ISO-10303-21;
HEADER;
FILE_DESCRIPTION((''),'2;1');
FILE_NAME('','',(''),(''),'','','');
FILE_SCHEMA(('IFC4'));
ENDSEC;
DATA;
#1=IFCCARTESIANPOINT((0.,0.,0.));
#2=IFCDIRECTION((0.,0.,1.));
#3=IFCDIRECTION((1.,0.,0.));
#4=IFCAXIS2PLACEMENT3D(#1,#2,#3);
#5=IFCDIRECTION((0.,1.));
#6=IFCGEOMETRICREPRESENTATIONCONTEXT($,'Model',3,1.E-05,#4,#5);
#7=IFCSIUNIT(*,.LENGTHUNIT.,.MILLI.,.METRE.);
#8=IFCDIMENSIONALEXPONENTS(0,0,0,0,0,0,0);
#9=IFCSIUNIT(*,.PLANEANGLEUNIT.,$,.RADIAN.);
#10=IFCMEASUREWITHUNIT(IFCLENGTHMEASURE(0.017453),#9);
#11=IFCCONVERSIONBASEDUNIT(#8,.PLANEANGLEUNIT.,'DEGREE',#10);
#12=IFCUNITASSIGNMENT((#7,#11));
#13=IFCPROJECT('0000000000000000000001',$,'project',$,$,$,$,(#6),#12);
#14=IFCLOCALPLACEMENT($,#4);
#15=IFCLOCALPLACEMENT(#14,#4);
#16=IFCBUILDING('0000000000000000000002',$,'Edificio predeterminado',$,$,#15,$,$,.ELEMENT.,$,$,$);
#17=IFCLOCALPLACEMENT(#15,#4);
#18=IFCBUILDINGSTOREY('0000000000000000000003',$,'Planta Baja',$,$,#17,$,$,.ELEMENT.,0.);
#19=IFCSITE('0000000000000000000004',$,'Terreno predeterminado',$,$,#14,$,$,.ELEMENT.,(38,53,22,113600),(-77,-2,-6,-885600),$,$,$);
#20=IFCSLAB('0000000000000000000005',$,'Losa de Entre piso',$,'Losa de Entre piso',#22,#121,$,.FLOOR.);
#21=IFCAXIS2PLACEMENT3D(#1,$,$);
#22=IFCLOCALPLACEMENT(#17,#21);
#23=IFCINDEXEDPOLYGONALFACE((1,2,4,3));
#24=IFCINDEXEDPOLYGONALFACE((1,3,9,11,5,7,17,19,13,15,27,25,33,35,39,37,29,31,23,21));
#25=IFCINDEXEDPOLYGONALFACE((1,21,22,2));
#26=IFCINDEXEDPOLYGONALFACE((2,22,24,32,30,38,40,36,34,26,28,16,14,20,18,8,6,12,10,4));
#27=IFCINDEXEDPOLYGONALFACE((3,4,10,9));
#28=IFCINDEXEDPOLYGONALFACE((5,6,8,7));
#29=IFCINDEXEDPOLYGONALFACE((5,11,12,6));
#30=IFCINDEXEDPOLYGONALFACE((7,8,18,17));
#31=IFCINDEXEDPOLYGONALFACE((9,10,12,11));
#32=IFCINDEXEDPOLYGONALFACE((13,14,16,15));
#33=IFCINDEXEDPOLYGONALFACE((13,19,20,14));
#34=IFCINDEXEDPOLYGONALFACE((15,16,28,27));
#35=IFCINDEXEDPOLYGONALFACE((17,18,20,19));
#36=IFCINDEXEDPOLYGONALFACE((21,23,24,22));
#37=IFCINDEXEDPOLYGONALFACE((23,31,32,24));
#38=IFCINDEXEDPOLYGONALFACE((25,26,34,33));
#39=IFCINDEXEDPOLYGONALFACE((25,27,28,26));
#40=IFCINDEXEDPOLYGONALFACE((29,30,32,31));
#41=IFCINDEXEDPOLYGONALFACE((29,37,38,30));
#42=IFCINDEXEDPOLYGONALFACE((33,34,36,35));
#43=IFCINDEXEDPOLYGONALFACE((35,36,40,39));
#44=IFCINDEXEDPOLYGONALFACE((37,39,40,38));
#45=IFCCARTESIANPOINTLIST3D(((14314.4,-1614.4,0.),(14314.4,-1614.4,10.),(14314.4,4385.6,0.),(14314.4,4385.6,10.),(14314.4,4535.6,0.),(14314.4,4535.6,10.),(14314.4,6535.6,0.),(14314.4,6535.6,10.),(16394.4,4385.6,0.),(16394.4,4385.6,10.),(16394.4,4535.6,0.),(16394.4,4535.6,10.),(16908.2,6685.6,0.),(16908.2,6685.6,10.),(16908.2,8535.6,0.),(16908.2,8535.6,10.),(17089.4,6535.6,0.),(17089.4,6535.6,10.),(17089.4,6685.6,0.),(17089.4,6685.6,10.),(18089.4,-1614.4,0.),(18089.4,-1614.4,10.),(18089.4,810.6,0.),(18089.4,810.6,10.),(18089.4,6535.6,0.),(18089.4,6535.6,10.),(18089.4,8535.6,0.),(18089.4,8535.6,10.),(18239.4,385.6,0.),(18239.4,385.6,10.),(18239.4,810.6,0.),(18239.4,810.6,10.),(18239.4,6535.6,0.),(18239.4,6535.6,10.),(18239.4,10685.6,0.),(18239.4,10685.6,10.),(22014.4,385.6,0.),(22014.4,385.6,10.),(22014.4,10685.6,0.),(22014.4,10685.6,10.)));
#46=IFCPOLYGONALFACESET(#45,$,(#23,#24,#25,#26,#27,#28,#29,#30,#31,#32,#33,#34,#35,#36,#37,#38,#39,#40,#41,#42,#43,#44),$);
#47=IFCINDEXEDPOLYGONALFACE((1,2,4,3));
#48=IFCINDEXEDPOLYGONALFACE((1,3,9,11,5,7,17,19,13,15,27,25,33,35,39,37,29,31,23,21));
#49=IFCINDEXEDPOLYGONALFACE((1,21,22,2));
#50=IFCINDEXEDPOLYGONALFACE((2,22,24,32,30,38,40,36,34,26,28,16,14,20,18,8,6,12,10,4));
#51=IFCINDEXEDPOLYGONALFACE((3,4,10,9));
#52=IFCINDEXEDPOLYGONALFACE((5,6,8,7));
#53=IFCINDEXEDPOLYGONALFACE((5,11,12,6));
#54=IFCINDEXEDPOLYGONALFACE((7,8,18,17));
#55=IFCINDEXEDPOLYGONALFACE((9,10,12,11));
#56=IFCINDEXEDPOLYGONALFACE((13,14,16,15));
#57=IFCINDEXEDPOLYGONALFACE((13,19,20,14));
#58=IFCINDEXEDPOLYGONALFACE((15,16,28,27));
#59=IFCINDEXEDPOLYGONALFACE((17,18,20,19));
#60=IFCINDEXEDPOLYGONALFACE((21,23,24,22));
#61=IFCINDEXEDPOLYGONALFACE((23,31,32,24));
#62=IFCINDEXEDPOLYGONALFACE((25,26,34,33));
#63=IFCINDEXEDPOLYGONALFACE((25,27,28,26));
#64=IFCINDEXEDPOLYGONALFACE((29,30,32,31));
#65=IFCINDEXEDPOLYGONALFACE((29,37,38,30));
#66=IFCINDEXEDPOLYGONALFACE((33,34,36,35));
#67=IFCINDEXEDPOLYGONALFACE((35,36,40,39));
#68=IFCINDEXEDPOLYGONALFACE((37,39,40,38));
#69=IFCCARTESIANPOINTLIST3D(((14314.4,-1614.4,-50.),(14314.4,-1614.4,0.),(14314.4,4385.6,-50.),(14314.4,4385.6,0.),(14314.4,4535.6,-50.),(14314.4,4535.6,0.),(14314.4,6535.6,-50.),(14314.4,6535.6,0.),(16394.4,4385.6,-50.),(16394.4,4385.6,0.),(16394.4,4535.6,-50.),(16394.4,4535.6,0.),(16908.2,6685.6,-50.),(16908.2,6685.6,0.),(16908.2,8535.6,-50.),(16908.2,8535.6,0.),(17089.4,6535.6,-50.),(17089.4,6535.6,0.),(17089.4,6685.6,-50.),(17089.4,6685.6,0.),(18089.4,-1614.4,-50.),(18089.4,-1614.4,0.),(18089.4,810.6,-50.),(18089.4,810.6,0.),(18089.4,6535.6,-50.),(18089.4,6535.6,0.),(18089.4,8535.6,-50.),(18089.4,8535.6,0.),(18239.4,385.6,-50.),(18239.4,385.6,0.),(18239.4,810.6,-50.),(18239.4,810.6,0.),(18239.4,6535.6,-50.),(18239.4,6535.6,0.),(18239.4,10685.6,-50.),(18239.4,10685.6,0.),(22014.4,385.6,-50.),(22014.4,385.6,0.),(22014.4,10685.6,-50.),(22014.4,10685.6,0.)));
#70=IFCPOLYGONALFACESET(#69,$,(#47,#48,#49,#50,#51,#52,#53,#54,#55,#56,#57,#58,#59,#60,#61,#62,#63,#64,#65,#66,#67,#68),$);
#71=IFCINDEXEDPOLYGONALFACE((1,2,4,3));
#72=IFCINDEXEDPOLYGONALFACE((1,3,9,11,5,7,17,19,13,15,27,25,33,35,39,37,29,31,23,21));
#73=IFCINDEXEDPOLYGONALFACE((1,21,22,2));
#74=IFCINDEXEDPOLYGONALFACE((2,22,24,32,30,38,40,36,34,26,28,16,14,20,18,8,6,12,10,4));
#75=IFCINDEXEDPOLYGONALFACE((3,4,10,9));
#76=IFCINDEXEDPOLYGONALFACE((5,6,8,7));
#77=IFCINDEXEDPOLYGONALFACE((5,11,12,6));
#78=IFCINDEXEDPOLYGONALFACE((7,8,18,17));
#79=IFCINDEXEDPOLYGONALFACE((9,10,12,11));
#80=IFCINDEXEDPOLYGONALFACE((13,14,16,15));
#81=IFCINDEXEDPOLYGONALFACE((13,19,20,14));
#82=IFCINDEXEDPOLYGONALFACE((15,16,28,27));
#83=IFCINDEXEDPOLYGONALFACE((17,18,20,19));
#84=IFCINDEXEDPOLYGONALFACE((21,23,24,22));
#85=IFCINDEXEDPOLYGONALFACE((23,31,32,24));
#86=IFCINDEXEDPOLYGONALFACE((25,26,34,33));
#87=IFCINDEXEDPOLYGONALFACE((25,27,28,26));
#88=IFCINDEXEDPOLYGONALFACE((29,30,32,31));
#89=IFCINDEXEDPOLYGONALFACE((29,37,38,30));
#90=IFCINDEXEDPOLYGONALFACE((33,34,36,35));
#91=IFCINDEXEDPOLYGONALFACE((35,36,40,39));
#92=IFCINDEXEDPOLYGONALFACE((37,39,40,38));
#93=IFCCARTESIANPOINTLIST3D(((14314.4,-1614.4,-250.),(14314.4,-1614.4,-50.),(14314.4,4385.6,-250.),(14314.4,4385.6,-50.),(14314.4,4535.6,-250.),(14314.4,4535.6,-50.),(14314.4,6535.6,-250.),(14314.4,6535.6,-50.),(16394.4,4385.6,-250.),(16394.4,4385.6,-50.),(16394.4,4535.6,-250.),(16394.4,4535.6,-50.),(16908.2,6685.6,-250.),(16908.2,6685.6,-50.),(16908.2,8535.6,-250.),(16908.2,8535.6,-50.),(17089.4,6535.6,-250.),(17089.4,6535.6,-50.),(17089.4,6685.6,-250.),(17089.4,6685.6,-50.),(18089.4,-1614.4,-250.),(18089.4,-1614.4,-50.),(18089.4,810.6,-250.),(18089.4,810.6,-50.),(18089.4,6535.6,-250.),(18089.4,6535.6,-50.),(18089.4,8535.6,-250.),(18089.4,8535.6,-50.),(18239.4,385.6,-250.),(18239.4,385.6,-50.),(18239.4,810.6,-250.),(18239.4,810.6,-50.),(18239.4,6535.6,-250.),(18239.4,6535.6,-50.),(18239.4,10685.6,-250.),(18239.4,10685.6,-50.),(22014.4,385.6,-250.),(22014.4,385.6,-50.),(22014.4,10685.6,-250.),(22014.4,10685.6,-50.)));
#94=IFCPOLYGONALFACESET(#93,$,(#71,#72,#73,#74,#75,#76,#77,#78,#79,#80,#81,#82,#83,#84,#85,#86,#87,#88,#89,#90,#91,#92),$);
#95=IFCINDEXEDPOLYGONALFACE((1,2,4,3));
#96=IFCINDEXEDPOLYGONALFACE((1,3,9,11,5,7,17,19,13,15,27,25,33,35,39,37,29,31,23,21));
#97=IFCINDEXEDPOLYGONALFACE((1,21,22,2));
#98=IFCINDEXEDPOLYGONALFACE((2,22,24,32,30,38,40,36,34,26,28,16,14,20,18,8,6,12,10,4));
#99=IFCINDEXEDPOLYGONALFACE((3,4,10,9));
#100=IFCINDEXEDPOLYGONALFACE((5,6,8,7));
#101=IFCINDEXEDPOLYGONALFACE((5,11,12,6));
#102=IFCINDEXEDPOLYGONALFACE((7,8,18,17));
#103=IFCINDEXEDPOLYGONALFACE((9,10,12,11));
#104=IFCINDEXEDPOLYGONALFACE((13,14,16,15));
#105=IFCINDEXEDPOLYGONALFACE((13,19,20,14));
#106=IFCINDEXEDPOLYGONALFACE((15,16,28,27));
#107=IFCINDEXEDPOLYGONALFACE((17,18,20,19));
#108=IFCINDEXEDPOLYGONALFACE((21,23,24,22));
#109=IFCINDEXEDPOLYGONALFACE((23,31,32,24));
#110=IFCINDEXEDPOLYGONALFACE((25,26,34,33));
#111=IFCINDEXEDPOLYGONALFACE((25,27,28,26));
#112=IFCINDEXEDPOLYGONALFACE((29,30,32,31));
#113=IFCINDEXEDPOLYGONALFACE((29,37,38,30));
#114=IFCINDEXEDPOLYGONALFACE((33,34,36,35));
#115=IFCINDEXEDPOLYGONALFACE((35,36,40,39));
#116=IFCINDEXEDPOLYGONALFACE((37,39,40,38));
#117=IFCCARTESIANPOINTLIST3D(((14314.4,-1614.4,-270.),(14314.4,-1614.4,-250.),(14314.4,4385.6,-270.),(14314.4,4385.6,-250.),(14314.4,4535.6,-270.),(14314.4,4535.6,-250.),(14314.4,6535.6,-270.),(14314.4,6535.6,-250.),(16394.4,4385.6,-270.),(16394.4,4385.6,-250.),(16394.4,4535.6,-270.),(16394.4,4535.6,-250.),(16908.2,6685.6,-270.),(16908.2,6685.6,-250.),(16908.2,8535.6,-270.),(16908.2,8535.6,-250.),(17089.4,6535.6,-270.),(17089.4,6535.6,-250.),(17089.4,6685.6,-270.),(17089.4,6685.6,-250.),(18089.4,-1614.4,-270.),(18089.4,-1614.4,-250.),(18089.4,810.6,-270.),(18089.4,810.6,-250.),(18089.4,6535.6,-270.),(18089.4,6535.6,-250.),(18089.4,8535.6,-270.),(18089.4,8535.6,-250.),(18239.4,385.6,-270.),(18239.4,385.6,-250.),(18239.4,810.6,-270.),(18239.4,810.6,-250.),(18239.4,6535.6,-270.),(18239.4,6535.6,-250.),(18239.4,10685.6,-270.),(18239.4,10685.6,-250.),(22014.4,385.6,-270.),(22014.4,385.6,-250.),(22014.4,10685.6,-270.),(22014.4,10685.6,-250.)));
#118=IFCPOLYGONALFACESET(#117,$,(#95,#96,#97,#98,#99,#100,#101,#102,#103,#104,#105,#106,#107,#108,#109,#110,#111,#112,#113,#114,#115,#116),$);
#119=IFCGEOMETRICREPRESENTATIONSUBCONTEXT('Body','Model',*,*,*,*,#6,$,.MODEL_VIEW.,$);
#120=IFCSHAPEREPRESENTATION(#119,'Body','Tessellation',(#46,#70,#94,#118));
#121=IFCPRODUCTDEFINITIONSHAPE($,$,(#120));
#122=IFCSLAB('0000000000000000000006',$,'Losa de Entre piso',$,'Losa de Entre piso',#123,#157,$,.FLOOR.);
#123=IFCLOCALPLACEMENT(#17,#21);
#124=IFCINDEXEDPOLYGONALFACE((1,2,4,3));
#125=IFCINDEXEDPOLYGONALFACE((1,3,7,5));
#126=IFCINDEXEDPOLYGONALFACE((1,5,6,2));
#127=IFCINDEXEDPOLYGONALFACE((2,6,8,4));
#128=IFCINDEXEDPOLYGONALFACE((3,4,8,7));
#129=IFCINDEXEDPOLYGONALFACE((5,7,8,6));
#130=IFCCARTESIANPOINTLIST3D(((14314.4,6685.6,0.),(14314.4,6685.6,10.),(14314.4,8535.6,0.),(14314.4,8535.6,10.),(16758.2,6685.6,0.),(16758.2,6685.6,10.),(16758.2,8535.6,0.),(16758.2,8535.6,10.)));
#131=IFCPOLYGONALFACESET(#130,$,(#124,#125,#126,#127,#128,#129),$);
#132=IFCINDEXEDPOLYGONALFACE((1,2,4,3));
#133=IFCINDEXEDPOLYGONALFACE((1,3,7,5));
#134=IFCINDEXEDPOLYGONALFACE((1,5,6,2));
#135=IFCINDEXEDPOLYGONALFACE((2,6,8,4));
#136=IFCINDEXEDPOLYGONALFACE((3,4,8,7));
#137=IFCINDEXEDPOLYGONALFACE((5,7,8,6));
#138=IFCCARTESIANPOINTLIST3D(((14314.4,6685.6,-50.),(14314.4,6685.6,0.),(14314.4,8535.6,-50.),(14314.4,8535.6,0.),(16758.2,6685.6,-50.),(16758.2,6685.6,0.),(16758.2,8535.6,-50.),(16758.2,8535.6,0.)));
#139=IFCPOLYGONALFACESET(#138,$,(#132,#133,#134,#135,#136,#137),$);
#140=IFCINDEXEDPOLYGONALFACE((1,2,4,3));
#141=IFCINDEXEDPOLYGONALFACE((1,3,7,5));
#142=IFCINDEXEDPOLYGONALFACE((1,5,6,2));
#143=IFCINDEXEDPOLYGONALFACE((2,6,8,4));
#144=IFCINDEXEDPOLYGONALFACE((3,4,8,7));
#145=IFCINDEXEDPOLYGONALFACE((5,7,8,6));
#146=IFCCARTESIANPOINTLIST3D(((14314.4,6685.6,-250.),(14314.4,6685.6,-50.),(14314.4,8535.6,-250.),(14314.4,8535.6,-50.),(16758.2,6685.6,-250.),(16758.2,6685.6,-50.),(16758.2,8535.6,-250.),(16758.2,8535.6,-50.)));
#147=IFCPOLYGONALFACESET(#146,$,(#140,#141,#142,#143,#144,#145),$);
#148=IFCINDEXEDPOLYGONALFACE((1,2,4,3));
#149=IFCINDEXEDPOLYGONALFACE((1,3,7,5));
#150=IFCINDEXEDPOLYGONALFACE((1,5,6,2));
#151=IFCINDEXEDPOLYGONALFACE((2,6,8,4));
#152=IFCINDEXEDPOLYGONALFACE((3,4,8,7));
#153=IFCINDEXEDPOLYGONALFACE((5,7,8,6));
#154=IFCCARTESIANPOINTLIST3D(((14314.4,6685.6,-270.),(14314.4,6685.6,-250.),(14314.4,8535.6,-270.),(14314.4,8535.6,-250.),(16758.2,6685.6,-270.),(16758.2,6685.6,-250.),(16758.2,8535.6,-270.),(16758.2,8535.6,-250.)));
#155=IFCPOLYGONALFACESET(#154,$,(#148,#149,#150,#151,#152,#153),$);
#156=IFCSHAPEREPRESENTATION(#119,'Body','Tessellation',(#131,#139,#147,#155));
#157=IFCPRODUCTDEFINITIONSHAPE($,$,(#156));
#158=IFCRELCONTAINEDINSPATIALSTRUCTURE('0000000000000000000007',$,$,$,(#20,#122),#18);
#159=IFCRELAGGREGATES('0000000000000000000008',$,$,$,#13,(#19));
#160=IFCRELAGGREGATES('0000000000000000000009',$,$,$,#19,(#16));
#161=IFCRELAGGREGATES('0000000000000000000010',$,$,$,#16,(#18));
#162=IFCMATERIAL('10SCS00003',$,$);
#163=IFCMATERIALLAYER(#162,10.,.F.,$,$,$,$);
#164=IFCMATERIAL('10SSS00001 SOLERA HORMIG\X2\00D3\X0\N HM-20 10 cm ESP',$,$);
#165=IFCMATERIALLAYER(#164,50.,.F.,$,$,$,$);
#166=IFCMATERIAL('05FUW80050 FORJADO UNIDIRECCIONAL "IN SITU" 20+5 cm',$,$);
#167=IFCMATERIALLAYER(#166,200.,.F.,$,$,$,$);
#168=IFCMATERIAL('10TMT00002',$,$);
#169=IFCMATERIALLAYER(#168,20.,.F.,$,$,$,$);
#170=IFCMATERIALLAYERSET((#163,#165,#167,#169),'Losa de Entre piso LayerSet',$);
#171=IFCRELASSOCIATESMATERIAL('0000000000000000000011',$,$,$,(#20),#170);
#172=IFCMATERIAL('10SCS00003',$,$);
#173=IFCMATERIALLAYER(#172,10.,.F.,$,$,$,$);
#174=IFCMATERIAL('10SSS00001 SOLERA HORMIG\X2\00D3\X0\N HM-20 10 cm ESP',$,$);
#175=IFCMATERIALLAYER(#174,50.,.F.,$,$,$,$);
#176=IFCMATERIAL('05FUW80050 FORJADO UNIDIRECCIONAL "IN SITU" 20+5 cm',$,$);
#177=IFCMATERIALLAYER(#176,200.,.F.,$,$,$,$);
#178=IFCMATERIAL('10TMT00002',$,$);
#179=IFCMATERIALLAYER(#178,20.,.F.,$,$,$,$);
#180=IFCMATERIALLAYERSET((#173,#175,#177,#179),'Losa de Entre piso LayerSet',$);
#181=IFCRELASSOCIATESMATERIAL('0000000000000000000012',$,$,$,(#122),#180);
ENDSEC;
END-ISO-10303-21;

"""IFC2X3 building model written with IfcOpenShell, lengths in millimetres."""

from ifc_helpers import new_model, entity, si_unit, converted_unit, direction, frame, origin_with_axes, place, context, subcontext, project, spatial, polyline, outline, extrude, material, layer, layer_set, layer_usage, element, save


model = new_model("IFC2X3")

# Units and contexts
model_context = context("Model", 3, precision=1e-05, world=origin_with_axes(), true_north=direction((0.0, 1.0)))
body_context = subcontext(model_context, "Body", "Model", "MODEL_VIEW")
ifc_project = project(units=[si_unit("LENGTHUNIT", "METRE", prefix="MILLI"), converted_unit("PLANEANGLEUNIT", "DEGREE", entity("IfcLengthMeasure", 0.017453), si_unit("PLANEANGLEUNIT", "RADIAN"), dimensions=[0, 0, 0, 0, 0, 0, 0])], contexts=[model_context])

# Site, building, storey
site_placement = place(None, origin_with_axes())
site = spatial("IfcSite", under=ifc_project, at=site_placement, Name="Terreno predeterminado", CompositionType="ELEMENT", RefLatitude=(38, 53, 22, 113600), RefLongitude=(-77, -2, -6, -885600))
building_placement = place(site_placement, origin_with_axes())
building = spatial("IfcBuilding", under=site, at=building_placement, Name="Edificio predeterminado", CompositionType="ELEMENT")
storey_placement = place(building_placement, origin_with_axes())
storey = spatial("IfcBuildingStorey", under=building, at=storey_placement, Name="Planta Baja", CompositionType="ELEMENT", Elevation=0.0)

# Slabs
ifc_material_1 = material(Name="10SCS00003")
ifc_layer_1 = layer(ifc_material_1, 10.0, ventilated=False)
ifc_material_2 = material(Name="10SSS00001 SOLERA HORMIGÓN HM-20 10 cm ESP")
ifc_layer_2 = layer(ifc_material_2, 50.0, ventilated=False)
ifc_material_3 = material(Name="05FUW80050 FORJADO UNIDIRECCIONAL \"IN SITU\" 20+5 cm")
ifc_layer_3 = layer(ifc_material_3, 200.0, ventilated=False)
ifc_material_4 = material(Name="10TMT00002")
ifc_layer_4 = layer(ifc_material_4, 20.0, ventilated=False)
ifc_layer_set_1 = layer_set([ifc_layer_1, ifc_layer_2, ifc_layer_3, ifc_layer_4], Name="Losa de Entre piso LayerSet")
ifc_layer_usage_1 = layer_usage(ifc_layer_set_1, "AXIS3", "POSITIVE", 0.0)
slab_1_placement = place(storey_placement, origin_with_axes())
element("IfcSlab", 1, at=slab_1_placement, inside=storey, material=ifc_layer_usage_1, Name="Losa de Entre piso", ObjectType="Losa de Entre piso", PredefinedType="FLOOR", context=body_context, shape_type="SweptSolid", body=[
    extrude(outline(polyline([(0.0, -6000.0), (3775.0, -6000.0), (3775.0, -3575.0), (3925.0, -3575.0), (3925.0, -4000.0), (7700.0, -4000.0), (7700.0, 6300.0), (3925.0, 6300.0), (3925.0, 2150.0), (3775.0, 2150.0), (3775.0, 4150.0), (2593.9, 4150.0), (2593.9, 2300.0), (2775.0, 2300.0), (2775.0, 2150.0), (0.0, 2150.0), (0.0, 150.0), (2080.0, 150.0), (2080.0, 0.0), (0.0, 0.0), (0.0, -6000.0)])), frame((14314.4, 4385.6, 0.0), z_axis=(0.0, 0.0, 1.0), x_axis=(1.0, 0.0, 0.0)), (0.0, 0.0, 1.0), 10.0),
    extrude(outline(polyline([(0.0, -6000.0), (3775.0, -6000.0), (3775.0, -3575.0), (3925.0, -3575.0), (3925.0, -4000.0), (7700.0, -4000.0), (7700.0, 6300.0), (3925.0, 6300.0), (3925.0, 2150.0), (3775.0, 2150.0), (3775.0, 4150.0), (2593.9, 4150.0), (2593.9, 2300.0), (2775.0, 2300.0), (2775.0, 2150.0), (0.0, 2150.0), (0.0, 150.0), (2080.0, 150.0), (2080.0, 0.0), (0.0, 0.0), (0.0, -6000.0)])), frame((14314.4, 4385.6, -50.0), z_axis=(0.0, 0.0, 1.0), x_axis=(1.0, 0.0, 0.0)), (0.0, 0.0, 1.0), 50.0),
    extrude(outline(polyline([(0.0, -6000.0), (3775.0, -6000.0), (3775.0, -3575.0), (3925.0, -3575.0), (3925.0, -4000.0), (7700.0, -4000.0), (7700.0, 6300.0), (3925.0, 6300.0), (3925.0, 2150.0), (3775.0, 2150.0), (3775.0, 4150.0), (2593.9, 4150.0), (2593.9, 2300.0), (2775.0, 2300.0), (2775.0, 2150.0), (0.0, 2150.0), (0.0, 150.0), (2080.0, 150.0), (2080.0, 0.0), (0.0, 0.0), (0.0, -6000.0)])), frame((14314.4, 4385.6, -250.0), z_axis=(0.0, 0.0, 1.0), x_axis=(1.0, 0.0, 0.0)), (0.0, 0.0, 1.0), 200.0),
    extrude(outline(polyline([(0.0, -6000.0), (3775.0, -6000.0), (3775.0, -3575.0), (3925.0, -3575.0), (3925.0, -4000.0), (7700.0, -4000.0), (7700.0, 6300.0), (3925.0, 6300.0), (3925.0, 2150.0), (3775.0, 2150.0), (3775.0, 4150.0), (2593.9, 4150.0), (2593.9, 2300.0), (2775.0, 2300.0), (2775.0, 2150.0), (0.0, 2150.0), (0.0, 150.0), (2080.0, 150.0), (2080.0, 0.0), (0.0, 0.0), (0.0, -6000.0)])), frame((14314.4, 4385.6, -270.0), z_axis=(0.0, 0.0, 1.0), x_axis=(1.0, 0.0, 0.0)), (0.0, 0.0, 1.0), 20.0),
])
ifc_material_5 = material(Name="10SCS00003")
ifc_layer_5 = layer(ifc_material_5, 10.0, ventilated=False)
ifc_material_6 = material(Name="10SSS00001 SOLERA HORMIGÓN HM-20 10 cm ESP")
ifc_layer_6 = layer(ifc_material_6, 50.0, ventilated=False)
ifc_material_7 = material(Name="05FUW80050 FORJADO UNIDIRECCIONAL \"IN SITU\" 20+5 cm")
ifc_layer_7 = layer(ifc_material_7, 200.0, ventilated=False)
ifc_material_8 = material(Name="10TMT00002")
ifc_layer_8 = layer(ifc_material_8, 20.0, ventilated=False)
ifc_layer_set_2 = layer_set([ifc_layer_5, ifc_layer_6, ifc_layer_7, ifc_layer_8], Name="Losa de Entre piso LayerSet")
ifc_layer_usage_2 = layer_usage(ifc_layer_set_2, "AXIS3", "NEGATIVE", 0.0)
slab_2_placement = place(storey_placement, origin_with_axes())
element("IfcSlab", 2, at=slab_2_placement, inside=storey, material=ifc_layer_usage_2, Name="Losa de Entre piso", ObjectType="Losa de Entre piso", PredefinedType="FLOOR", context=body_context, shape_type="SweptSolid", body=[
    extrude(outline(polyline([(0.0, 2443.9), (1850.0, 2443.9), (1850.0, 0.0), (0.0, 0.0), (0.0, 2443.9)])), frame((14314.4, 6685.6, 0.0), z_axis=(0.0, 0.0, -1.0), x_axis=(0.0, 1.0, 0.0)), (0.0, 0.0, -1.0), 10.0),
    extrude(outline(polyline([(0.0, 2443.9), (1850.0, 2443.9), (1850.0, 0.0), (0.0, 0.0), (0.0, 2443.9)])), frame((14314.4, 6685.6, -50.0), z_axis=(0.0, 0.0, -1.0), x_axis=(0.0, 1.0, 0.0)), (0.0, 0.0, -1.0), 50.0),
    extrude(outline(polyline([(0.0, 2443.9), (1850.0, 2443.9), (1850.0, 0.0), (0.0, 0.0), (0.0, 2443.9)])), frame((14314.4, 6685.6, -250.0), z_axis=(0.0, 0.0, -1.0), x_axis=(0.0, 1.0, 0.0)), (0.0, 0.0, -1.0), 200.0),
    extrude(outline(polyline([(0.0, 2443.9), (1850.0, 2443.9), (1850.0, 0.0), (0.0, 0.0), (0.0, 2443.9)])), frame((14314.4, 6685.6, -270.0), z_axis=(0.0, 0.0, -1.0), x_axis=(0.0, 1.0, 0.0)), (0.0, 0.0, -1.0), 20.0),
])

save(model, "model.ifc")
